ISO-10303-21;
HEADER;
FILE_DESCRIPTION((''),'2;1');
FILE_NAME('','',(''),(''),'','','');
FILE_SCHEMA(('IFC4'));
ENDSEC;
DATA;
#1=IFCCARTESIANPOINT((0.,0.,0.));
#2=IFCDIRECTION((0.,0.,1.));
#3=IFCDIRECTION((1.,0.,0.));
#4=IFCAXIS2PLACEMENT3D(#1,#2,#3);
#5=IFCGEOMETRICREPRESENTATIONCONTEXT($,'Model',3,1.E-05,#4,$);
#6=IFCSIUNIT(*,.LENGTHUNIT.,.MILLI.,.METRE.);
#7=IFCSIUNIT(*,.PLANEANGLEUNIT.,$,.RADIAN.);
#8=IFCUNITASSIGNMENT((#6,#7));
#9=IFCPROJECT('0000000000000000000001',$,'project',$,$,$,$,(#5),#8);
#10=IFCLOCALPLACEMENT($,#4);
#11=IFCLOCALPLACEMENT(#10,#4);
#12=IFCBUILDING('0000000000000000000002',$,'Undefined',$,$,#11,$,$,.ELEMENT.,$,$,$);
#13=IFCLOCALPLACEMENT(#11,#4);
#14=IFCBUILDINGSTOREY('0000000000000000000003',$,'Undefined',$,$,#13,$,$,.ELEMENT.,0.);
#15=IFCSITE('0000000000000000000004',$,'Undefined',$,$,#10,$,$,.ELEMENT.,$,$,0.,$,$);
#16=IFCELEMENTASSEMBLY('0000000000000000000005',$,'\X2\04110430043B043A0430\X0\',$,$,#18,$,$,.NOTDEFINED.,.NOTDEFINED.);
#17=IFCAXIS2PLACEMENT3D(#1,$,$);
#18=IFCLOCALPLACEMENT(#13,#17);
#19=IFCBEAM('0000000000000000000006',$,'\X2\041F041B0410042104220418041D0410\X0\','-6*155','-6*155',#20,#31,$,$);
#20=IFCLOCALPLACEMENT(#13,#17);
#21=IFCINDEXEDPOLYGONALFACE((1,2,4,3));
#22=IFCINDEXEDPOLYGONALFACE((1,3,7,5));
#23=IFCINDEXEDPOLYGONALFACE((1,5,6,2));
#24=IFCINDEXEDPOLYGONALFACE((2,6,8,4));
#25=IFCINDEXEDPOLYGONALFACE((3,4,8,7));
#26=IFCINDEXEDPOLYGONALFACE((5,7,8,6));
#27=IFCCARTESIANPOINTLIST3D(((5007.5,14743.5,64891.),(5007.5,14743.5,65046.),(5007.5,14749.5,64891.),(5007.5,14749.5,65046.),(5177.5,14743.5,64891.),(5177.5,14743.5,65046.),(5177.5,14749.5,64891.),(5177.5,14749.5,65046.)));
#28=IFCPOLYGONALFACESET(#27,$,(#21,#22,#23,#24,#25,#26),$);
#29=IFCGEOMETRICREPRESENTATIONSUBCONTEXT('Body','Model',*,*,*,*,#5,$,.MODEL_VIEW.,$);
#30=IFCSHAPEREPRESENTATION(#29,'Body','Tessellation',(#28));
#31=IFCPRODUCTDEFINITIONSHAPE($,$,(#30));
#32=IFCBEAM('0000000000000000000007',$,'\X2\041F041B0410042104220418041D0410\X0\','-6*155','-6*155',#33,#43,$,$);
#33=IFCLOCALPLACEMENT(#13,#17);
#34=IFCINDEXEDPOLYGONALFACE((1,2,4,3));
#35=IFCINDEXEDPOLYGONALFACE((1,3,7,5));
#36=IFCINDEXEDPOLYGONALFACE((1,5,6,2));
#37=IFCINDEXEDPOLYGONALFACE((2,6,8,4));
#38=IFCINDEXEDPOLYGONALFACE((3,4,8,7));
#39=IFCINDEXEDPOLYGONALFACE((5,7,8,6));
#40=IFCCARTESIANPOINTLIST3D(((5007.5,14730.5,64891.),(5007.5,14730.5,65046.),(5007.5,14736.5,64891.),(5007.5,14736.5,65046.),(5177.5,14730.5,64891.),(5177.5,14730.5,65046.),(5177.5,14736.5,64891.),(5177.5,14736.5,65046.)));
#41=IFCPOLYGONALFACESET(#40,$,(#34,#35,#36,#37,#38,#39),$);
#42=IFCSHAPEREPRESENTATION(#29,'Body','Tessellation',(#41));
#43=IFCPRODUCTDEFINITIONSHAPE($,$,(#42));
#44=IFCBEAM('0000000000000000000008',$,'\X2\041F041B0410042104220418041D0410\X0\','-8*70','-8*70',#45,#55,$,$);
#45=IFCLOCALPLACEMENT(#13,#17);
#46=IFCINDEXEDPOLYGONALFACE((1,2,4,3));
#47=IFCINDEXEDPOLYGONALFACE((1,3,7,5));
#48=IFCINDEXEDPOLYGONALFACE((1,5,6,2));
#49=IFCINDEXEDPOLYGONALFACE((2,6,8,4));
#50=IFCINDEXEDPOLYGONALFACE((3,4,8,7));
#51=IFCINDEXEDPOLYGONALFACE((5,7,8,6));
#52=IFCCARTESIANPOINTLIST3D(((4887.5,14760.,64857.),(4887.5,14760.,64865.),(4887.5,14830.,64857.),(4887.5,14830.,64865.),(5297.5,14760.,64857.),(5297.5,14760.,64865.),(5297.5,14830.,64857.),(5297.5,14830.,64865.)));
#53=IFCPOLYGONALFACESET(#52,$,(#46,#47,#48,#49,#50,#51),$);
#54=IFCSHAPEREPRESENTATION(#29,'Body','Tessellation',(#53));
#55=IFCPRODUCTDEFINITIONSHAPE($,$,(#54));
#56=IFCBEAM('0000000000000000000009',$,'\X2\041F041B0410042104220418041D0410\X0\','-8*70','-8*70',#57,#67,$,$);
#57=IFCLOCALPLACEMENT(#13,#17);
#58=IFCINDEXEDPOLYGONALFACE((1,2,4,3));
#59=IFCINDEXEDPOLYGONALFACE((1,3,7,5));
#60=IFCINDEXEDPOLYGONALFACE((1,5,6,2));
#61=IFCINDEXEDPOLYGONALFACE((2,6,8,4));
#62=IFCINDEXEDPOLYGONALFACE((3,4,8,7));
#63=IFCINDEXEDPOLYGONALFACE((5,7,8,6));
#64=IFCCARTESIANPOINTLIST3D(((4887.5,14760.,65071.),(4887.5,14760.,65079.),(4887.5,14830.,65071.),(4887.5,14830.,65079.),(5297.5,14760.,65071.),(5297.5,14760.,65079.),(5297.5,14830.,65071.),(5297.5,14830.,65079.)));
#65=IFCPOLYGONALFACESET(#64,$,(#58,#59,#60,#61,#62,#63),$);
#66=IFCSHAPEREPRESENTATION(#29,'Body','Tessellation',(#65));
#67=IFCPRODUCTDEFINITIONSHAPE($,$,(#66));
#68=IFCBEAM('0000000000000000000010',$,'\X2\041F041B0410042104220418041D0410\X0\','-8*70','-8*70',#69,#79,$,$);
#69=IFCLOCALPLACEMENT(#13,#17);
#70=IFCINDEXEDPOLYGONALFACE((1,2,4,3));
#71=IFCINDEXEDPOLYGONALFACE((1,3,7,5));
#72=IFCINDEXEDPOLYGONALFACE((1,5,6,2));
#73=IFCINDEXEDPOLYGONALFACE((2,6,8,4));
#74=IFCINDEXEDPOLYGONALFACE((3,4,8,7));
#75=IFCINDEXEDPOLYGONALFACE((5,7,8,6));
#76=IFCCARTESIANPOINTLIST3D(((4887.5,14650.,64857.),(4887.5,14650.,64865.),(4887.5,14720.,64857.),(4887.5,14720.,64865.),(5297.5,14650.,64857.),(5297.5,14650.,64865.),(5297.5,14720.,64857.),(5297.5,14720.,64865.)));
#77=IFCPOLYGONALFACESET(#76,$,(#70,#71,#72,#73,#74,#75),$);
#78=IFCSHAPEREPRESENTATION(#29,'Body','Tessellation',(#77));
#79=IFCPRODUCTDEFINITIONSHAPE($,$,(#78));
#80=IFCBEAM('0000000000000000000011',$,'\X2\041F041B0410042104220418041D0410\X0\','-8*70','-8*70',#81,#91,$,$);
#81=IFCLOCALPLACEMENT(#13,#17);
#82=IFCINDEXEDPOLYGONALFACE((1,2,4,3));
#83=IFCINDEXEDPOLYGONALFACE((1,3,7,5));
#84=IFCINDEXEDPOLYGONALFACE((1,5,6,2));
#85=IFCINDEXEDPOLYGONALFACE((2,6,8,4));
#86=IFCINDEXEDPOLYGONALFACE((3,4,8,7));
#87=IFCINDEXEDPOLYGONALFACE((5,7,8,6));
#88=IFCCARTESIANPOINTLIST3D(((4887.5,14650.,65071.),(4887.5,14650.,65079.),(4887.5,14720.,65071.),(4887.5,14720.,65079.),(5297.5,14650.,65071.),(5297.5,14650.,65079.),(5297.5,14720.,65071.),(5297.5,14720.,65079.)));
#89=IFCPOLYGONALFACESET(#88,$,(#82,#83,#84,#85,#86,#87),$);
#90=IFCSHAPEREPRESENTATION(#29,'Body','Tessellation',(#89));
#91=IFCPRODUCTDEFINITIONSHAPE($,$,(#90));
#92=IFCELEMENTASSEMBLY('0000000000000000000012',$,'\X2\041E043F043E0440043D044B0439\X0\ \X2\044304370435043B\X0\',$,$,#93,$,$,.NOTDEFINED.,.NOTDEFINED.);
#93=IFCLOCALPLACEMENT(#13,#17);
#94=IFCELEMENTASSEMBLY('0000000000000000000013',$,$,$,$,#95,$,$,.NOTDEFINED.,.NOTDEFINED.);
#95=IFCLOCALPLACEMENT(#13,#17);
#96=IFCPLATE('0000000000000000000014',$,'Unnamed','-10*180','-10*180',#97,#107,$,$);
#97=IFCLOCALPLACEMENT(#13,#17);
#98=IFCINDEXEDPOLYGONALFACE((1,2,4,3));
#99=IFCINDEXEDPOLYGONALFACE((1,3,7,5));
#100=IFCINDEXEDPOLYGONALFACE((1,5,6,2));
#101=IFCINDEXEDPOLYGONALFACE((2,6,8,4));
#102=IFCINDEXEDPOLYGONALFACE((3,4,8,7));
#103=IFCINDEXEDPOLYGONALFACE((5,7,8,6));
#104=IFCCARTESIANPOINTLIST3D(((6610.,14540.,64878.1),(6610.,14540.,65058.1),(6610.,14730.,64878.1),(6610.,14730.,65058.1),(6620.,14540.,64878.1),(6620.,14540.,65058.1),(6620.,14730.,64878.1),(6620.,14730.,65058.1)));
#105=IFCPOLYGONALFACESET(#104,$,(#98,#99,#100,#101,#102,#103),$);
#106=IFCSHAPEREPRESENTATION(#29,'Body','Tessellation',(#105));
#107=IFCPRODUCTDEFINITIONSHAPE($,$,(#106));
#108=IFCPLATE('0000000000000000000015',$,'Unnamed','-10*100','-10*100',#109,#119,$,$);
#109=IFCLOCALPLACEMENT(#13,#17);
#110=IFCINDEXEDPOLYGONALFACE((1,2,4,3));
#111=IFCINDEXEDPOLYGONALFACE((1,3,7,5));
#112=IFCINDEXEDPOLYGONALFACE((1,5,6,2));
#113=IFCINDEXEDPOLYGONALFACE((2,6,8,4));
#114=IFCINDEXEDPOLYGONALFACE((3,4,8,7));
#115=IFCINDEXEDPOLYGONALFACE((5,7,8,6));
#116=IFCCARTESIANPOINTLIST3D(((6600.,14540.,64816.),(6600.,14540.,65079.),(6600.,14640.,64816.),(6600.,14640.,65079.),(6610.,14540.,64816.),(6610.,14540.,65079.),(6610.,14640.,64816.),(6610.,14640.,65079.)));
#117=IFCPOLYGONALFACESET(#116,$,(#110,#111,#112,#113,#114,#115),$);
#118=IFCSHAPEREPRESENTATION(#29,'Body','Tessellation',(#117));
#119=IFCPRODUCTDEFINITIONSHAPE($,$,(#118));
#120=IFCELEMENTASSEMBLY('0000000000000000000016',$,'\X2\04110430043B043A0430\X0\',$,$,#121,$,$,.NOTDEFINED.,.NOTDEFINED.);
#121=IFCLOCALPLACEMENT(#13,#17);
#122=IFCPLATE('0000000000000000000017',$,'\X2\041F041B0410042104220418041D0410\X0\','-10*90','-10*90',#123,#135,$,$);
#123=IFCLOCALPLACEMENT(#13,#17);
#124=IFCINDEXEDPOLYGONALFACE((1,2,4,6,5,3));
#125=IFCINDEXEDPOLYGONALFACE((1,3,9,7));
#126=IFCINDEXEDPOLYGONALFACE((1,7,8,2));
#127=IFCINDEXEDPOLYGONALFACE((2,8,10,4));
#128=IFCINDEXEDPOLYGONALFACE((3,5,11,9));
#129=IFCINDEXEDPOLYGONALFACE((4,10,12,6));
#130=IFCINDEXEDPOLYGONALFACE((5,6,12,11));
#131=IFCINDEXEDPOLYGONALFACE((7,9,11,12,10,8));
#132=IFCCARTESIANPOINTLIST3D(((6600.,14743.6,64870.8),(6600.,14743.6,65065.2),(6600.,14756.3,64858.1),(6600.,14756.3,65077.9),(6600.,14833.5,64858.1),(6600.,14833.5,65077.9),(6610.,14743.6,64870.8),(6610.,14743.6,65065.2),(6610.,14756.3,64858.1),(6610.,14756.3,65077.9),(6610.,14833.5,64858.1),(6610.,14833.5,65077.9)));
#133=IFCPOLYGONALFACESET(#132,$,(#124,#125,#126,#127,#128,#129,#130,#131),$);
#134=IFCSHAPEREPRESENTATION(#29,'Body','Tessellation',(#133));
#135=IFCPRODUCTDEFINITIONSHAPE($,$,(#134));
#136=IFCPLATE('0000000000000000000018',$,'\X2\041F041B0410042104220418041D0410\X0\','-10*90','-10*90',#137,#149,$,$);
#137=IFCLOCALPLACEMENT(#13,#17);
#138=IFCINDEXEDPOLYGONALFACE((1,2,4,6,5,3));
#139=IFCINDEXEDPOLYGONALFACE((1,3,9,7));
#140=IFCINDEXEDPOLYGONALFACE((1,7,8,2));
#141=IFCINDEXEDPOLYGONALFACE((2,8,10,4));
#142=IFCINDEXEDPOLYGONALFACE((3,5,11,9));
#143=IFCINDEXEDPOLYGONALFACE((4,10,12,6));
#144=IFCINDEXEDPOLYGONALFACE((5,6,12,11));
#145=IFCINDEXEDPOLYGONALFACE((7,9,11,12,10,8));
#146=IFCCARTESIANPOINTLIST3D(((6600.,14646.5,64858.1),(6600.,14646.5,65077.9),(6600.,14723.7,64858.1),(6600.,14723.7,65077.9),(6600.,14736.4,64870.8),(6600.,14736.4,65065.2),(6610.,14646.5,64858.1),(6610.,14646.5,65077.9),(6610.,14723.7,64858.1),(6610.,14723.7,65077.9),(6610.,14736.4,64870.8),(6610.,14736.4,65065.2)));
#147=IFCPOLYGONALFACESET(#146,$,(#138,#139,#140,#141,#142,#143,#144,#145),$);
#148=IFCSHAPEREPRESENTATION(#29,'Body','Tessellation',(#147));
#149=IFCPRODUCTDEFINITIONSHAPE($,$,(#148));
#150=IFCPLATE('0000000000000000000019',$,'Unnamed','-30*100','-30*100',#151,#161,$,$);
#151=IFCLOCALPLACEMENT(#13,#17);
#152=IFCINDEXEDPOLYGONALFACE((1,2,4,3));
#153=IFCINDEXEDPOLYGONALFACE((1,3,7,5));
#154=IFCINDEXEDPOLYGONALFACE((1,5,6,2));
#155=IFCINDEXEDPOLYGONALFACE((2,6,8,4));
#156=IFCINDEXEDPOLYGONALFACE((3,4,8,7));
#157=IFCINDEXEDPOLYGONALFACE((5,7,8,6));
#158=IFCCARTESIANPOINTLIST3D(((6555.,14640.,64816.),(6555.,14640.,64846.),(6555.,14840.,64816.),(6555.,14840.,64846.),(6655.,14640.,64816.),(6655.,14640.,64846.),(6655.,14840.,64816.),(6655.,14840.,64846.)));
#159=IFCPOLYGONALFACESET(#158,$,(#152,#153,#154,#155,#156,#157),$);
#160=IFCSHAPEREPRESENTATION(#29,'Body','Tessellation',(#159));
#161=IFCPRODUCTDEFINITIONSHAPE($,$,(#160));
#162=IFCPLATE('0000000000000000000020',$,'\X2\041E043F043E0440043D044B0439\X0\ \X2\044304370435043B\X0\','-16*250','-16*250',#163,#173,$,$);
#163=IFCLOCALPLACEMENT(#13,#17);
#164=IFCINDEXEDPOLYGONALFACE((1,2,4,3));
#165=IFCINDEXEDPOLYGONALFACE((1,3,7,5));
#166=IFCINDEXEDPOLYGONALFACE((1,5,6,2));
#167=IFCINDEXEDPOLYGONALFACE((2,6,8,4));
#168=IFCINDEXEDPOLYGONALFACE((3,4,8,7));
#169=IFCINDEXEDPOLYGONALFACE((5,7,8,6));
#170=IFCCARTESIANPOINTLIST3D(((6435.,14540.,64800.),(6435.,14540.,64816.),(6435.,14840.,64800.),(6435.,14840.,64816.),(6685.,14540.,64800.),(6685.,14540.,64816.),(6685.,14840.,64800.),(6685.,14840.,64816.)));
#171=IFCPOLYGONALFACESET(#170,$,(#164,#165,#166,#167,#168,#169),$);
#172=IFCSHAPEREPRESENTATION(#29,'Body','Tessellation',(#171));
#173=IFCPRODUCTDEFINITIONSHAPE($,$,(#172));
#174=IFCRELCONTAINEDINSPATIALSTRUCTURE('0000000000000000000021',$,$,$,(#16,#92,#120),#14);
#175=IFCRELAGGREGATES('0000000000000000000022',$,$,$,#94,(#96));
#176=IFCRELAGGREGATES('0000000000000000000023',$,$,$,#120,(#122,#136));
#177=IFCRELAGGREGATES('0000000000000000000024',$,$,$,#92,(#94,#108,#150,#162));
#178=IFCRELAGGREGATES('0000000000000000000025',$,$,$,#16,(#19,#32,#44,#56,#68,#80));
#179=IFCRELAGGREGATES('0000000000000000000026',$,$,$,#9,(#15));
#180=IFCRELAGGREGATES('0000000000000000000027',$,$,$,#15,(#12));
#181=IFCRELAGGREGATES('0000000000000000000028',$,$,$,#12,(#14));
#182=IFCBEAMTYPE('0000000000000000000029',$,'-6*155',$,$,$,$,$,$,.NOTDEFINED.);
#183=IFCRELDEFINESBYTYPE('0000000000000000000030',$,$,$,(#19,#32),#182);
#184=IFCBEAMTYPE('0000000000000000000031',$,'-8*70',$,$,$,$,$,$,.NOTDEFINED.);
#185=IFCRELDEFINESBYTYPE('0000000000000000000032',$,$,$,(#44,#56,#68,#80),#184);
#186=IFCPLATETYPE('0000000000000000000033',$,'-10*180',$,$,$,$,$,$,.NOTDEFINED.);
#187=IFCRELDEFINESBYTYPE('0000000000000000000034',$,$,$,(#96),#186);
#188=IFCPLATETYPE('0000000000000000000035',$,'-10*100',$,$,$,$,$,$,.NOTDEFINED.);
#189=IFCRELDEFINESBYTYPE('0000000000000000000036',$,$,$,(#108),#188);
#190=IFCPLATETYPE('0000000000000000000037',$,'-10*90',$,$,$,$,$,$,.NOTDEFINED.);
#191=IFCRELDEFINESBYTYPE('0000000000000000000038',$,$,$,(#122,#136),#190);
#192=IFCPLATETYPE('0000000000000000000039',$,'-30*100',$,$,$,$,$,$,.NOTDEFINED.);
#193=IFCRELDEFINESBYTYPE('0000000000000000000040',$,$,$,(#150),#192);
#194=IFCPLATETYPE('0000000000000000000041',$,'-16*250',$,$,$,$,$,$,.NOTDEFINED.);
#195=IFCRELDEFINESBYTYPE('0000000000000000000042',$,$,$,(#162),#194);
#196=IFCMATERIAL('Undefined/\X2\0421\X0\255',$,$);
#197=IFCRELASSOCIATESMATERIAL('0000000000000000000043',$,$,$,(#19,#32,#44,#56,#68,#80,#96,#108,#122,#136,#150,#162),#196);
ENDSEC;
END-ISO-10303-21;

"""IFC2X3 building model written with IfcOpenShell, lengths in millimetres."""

from ifc_helpers import new_model, si_unit, frame, origin_with_axes, origin_2d_with_axis, place, context, subcontext, project, spatial, polyline, rectangle, outline, extrude, material, type_object, element, aggregate, save


model = new_model("IFC2X3")

# Units and contexts
model_context = context("Model", 3, precision=1e-05, world=origin_with_axes())
body_context = subcontext(model_context, "Body", "Model", "MODEL_VIEW")
ifc_project = project(units=[si_unit("LENGTHUNIT", "METRE", prefix="MILLI"), si_unit("PLANEANGLEUNIT", "RADIAN")], contexts=[model_context])

# Site, building, storey
site_placement = place(None, origin_with_axes())
site = spatial("IfcSite", under=ifc_project, at=site_placement, Name="Undefined", CompositionType="ELEMENT", RefElevation=0.0)
building_placement = place(site_placement, origin_with_axes())
building = spatial("IfcBuilding", under=site, at=building_placement, Name="Undefined", CompositionType="ELEMENT")
storey_placement = place(building_placement, origin_with_axes())
storey = spatial("IfcBuildingStorey", under=building, at=storey_placement, Name="Undefined", CompositionType="ELEMENT", Elevation=0.0)

# Element assembly, beams
assembly_1_placement = place(storey_placement, origin_with_axes())
assembly_1 = element("IfcElementAssembly", 1, at=assembly_1_placement, inside=storey, Name="Балка", AssemblyPlace="NOTDEFINED", PredefinedType="NOTDEFINED")
ifc_material_1 = material(Name="Undefined/С255")
beam_type_1 = type_object("IfcBeamType", Name="-6*155", PredefinedType="NOTDEFINED")
beam_1_placement = place(assembly_1_placement, frame((5007.5, 14746.5, 64968.5), z_axis=(0.0, 0.0, 1.0), x_axis=(1.0, 0.0, 0.0)))
beam_1 = element("IfcBeam", 2, at=beam_1_placement, type_object=beam_type_1, material=ifc_material_1, Name="ПЛАСТИНА", Description="-6*155", ObjectType="-6*155", context=body_context, shape_type="SweptSolid", body=[
    extrude(rectangle(XDim=6.0, YDim=155.0, at=origin_2d_with_axis()), frame((170.0, 0.0, 0.0), z_axis=(-1.0, 0.0, 0.0), x_axis=(0.0, -1.0, 0.0)), (0.0, 0.0, 1.0), 170.0),
])
beam_2_placement = place(assembly_1_placement, frame((5007.5, 14733.5, 64968.5), z_axis=(0.0, 0.0, 1.0), x_axis=(1.0, 0.0, 0.0)))
beam_2 = element("IfcBeam", 3, at=beam_2_placement, type_object=beam_type_1, material=ifc_material_1, Name="ПЛАСТИНА", Description="-6*155", ObjectType="-6*155", context=body_context, shape_type="SweptSolid", body=[
    extrude(rectangle(XDim=6.0, YDim=155.0, at=origin_2d_with_axis()), frame((170.0, 0.0, 0.0), z_axis=(-1.0, 0.0, 0.0), x_axis=(0.0, -1.0, 0.0)), (0.0, 0.0, 1.0), 170.0),
])
beam_type_2 = type_object("IfcBeamType", Name="-8*70", PredefinedType="NOTDEFINED")
beam_3_placement = place(assembly_1_placement, frame((5297.5, 14795.0, 64861.0), z_axis=(0.0, -1.0, 0.0), x_axis=(-1.0, 0.0, 0.0)))
beam_3 = element("IfcBeam", 4, at=beam_3_placement, type_object=beam_type_2, material=ifc_material_1, Name="ПЛАСТИНА", Description="-8*70", ObjectType="-8*70", context=body_context, shape_type="SweptSolid", body=[
    extrude(rectangle(XDim=8.0, YDim=70.0, at=origin_2d_with_axis()), frame((410.0, 0.0, 0.0), z_axis=(-1.0, 0.0, 0.0), x_axis=(0.0, -1.0, 0.0)), (0.0, 0.0, 1.0), 410.0),
])
beam_4_placement = place(assembly_1_placement, frame((5297.5, 14795.0, 65075.0), z_axis=(0.0, -1.0, 0.0), x_axis=(-1.0, 0.0, 0.0)))
beam_4 = element("IfcBeam", 5, at=beam_4_placement, type_object=beam_type_2, material=ifc_material_1, Name="ПЛАСТИНА", Description="-8*70", ObjectType="-8*70", context=body_context, shape_type="SweptSolid", body=[
    extrude(rectangle(XDim=8.0, YDim=70.0, at=origin_2d_with_axis()), frame((410.0, 0.0, 0.0), z_axis=(-1.0, 0.0, 0.0), x_axis=(0.0, -1.0, 0.0)), (0.0, 0.0, 1.0), 410.0),
])
beam_5_placement = place(assembly_1_placement, frame((5297.5, 14685.0, 64861.0), z_axis=(0.0, -1.0, 0.0), x_axis=(-1.0, 0.0, 0.0)))
beam_5 = element("IfcBeam", 6, at=beam_5_placement, type_object=beam_type_2, material=ifc_material_1, Name="ПЛАСТИНА", Description="-8*70", ObjectType="-8*70", context=body_context, shape_type="SweptSolid", body=[
    extrude(rectangle(XDim=8.0, YDim=70.0, at=origin_2d_with_axis()), frame((410.0, 0.0, 0.0), z_axis=(-1.0, 0.0, 0.0), x_axis=(0.0, -1.0, 0.0)), (0.0, 0.0, 1.0), 410.0),
])
beam_6_placement = place(assembly_1_placement, frame((5297.5, 14685.0, 65075.0), z_axis=(0.0, -1.0, 0.0), x_axis=(-1.0, 0.0, 0.0)))
beam_6 = element("IfcBeam", 7, at=beam_6_placement, type_object=beam_type_2, material=ifc_material_1, Name="ПЛАСТИНА", Description="-8*70", ObjectType="-8*70", context=body_context, shape_type="SweptSolid", body=[
    extrude(rectangle(XDim=8.0, YDim=70.0, at=origin_2d_with_axis()), frame((410.0, 0.0, 0.0), z_axis=(-1.0, 0.0, 0.0), x_axis=(0.0, -1.0, 0.0)), (0.0, 0.0, 1.0), 410.0),
])

# Element assemblies, plates
assembly_2_placement = place(storey_placement, origin_with_axes())
assembly_2 = element("IfcElementAssembly", 8, at=assembly_2_placement, inside=storey, Name="Опорный узел", AssemblyPlace="NOTDEFINED", PredefinedType="NOTDEFINED")
assembly_3_placement = place(assembly_2_placement, origin_with_axes())
assembly_3 = element("IfcElementAssembly", 9, at=assembly_3_placement, AssemblyPlace="NOTDEFINED", PredefinedType="NOTDEFINED")
plate_type_1 = type_object("IfcPlateType", Name="-10*180", PredefinedType="NOTDEFINED")
plate_1_placement = place(assembly_3_placement, frame((6615.0, 14730.0, 65058.1), z_axis=(1.0, 0.0, 0.0), x_axis=(0.0, -1.0, 0.0)))
plate_1 = element("IfcPlate", 10, at=plate_1_placement, type_object=plate_type_1, material=ifc_material_1, Name="Unnamed", Description="-10*180", ObjectType="-10*180", context=body_context, shape_type="SweptSolid", body=[
    extrude(outline(polyline([(0.0, 0.0), (190.0, 0.0), (190.0, 180.0), (0.0, 180.0), (0.0, 0.0)])), frame((0.0, 0.0, -5.0), z_axis=(0.0, 0.0, 1.0), x_axis=(1.0, 0.0, 0.0)), (0.0, 0.0, 1.0), 10.0),
])
aggregate(assembly_3, [plate_1])
plate_type_2 = type_object("IfcPlateType", Name="-10*100", PredefinedType="NOTDEFINED")
plate_2_placement = place(assembly_2_placement, frame((6605.0, 14540.0, 64816.0), z_axis=(-1.0, 0.0, 0.0), x_axis=(0.0, 0.0, 1.0)))
plate_2 = element("IfcPlate", 11, at=plate_2_placement, type_object=plate_type_2, material=ifc_material_1, Name="Unnamed", Description="-10*100", ObjectType="-10*100", context=body_context, shape_type="SweptSolid", body=[
    extrude(outline(polyline([(0.0, 0.0), (263.0, 0.0), (263.0, 100.0), (0.0, 100.0), (0.0, 0.0)])), frame((0.0, 0.0, -5.0), z_axis=(0.0, 0.0, 1.0), x_axis=(1.0, 0.0, 0.0)), (0.0, 0.0, 1.0), 10.0),
])

# Element assembly, plates
assembly_4_placement = place(storey_placement, origin_with_axes())
assembly_4 = element("IfcElementAssembly", 12, at=assembly_4_placement, inside=storey, Name="Балка", AssemblyPlace="NOTDEFINED", PredefinedType="NOTDEFINED")
plate_type_3 = type_object("IfcPlateType", Name="-10*90", PredefinedType="NOTDEFINED")
plate_3_placement = place(assembly_4_placement, frame((6605.0, 14743.6, 65077.9), z_axis=(-1.0, 0.0, 0.0), x_axis=(0.0, 1.0, 0.0)))
plate_3 = element("IfcPlate", 13, at=plate_3_placement, type_object=plate_type_3, material=ifc_material_1, Name="ПЛАСТИНА", Description="-10*90", ObjectType="-10*90", context=body_context, shape_type="SweptSolid", body=[
    extrude(outline(polyline([(0.0, 12.7), (12.7, 0.0), (89.9, 0.0), (89.9, 219.8), (12.7, 219.8), (0.0, 207.1), (0.0, 12.7)])), frame((0.0, 0.0, -5.0), z_axis=(0.0, 0.0, 1.0), x_axis=(1.0, 0.0, 0.0)), (0.0, 0.0, 1.0), 10.0),
])
plate_4_placement = place(assembly_4_placement, frame((6605.0, 14646.5, 65077.9), z_axis=(-1.0, 0.0, 0.0), x_axis=(0.0, 1.0, 0.0)))
plate_4 = element("IfcPlate", 14, at=plate_4_placement, type_object=plate_type_3, material=ifc_material_1, Name="ПЛАСТИНА", Description="-10*90", ObjectType="-10*90", context=body_context, shape_type="SweptSolid", body=[
    extrude(outline(polyline([(0.0, 0.0), (77.2, 0.0), (89.9, 12.7), (89.9, 207.1), (77.2, 219.8), (0.0, 219.8), (0.0, 0.0)])), frame((0.0, 0.0, -5.0), z_axis=(0.0, 0.0, 1.0), x_axis=(1.0, 0.0, 0.0)), (0.0, 0.0, 1.0), 10.0),
])
aggregate(assembly_4, [plate_3, plate_4])

# Plates
plate_type_4 = type_object("IfcPlateType", Name="-30*100", PredefinedType="NOTDEFINED")
plate_5_placement = place(assembly_2_placement, frame((6655.0, 14640.0, 64831.0), z_axis=(0.0, 0.0, 1.0), x_axis=(0.0, 1.0, 0.0)))
plate_5 = element("IfcPlate", 15, at=plate_5_placement, type_object=plate_type_4, material=ifc_material_1, Name="Unnamed", Description="-30*100", ObjectType="-30*100", context=body_context, shape_type="SweptSolid", body=[
    extrude(outline(polyline([(0.0, 0.0), (200.0, 0.0), (200.0, 100.0), (0.0, 100.0), (0.0, 0.0)])), frame((0.0, 0.0, -15.0), z_axis=(0.0, 0.0, 1.0), x_axis=(1.0, 0.0, 0.0)), (0.0, 0.0, 1.0), 30.0),
])
plate_type_5 = type_object("IfcPlateType", Name="-16*250", PredefinedType="NOTDEFINED")
plate_6_placement = place(assembly_2_placement, frame((6685.0, 14540.0, 64808.0), z_axis=(0.0, 0.0, 1.0), x_axis=(0.0, 1.0, 0.0)))
plate_6 = element("IfcPlate", 16, at=plate_6_placement, type_object=plate_type_5, material=ifc_material_1, Name="Опорный узел", Description="-16*250", ObjectType="-16*250", context=body_context, shape_type="SweptSolid", body=[
    extrude(outline(polyline([(0.0, 0.0), (300.0, 0.0), (300.0, 250.0), (0.0, 250.0), (0.0, 0.0)])), frame((0.0, 0.0, -8.0), z_axis=(0.0, 0.0, 1.0), x_axis=(1.0, 0.0, 0.0)), (0.0, 0.0, 1.0), 16.0),
])

aggregate(assembly_2, [assembly_3, plate_2, plate_5, plate_6])
aggregate(assembly_1, [beam_1, beam_2, beam_3, beam_4, beam_5, beam_6])

save(model, "model.ifc")
